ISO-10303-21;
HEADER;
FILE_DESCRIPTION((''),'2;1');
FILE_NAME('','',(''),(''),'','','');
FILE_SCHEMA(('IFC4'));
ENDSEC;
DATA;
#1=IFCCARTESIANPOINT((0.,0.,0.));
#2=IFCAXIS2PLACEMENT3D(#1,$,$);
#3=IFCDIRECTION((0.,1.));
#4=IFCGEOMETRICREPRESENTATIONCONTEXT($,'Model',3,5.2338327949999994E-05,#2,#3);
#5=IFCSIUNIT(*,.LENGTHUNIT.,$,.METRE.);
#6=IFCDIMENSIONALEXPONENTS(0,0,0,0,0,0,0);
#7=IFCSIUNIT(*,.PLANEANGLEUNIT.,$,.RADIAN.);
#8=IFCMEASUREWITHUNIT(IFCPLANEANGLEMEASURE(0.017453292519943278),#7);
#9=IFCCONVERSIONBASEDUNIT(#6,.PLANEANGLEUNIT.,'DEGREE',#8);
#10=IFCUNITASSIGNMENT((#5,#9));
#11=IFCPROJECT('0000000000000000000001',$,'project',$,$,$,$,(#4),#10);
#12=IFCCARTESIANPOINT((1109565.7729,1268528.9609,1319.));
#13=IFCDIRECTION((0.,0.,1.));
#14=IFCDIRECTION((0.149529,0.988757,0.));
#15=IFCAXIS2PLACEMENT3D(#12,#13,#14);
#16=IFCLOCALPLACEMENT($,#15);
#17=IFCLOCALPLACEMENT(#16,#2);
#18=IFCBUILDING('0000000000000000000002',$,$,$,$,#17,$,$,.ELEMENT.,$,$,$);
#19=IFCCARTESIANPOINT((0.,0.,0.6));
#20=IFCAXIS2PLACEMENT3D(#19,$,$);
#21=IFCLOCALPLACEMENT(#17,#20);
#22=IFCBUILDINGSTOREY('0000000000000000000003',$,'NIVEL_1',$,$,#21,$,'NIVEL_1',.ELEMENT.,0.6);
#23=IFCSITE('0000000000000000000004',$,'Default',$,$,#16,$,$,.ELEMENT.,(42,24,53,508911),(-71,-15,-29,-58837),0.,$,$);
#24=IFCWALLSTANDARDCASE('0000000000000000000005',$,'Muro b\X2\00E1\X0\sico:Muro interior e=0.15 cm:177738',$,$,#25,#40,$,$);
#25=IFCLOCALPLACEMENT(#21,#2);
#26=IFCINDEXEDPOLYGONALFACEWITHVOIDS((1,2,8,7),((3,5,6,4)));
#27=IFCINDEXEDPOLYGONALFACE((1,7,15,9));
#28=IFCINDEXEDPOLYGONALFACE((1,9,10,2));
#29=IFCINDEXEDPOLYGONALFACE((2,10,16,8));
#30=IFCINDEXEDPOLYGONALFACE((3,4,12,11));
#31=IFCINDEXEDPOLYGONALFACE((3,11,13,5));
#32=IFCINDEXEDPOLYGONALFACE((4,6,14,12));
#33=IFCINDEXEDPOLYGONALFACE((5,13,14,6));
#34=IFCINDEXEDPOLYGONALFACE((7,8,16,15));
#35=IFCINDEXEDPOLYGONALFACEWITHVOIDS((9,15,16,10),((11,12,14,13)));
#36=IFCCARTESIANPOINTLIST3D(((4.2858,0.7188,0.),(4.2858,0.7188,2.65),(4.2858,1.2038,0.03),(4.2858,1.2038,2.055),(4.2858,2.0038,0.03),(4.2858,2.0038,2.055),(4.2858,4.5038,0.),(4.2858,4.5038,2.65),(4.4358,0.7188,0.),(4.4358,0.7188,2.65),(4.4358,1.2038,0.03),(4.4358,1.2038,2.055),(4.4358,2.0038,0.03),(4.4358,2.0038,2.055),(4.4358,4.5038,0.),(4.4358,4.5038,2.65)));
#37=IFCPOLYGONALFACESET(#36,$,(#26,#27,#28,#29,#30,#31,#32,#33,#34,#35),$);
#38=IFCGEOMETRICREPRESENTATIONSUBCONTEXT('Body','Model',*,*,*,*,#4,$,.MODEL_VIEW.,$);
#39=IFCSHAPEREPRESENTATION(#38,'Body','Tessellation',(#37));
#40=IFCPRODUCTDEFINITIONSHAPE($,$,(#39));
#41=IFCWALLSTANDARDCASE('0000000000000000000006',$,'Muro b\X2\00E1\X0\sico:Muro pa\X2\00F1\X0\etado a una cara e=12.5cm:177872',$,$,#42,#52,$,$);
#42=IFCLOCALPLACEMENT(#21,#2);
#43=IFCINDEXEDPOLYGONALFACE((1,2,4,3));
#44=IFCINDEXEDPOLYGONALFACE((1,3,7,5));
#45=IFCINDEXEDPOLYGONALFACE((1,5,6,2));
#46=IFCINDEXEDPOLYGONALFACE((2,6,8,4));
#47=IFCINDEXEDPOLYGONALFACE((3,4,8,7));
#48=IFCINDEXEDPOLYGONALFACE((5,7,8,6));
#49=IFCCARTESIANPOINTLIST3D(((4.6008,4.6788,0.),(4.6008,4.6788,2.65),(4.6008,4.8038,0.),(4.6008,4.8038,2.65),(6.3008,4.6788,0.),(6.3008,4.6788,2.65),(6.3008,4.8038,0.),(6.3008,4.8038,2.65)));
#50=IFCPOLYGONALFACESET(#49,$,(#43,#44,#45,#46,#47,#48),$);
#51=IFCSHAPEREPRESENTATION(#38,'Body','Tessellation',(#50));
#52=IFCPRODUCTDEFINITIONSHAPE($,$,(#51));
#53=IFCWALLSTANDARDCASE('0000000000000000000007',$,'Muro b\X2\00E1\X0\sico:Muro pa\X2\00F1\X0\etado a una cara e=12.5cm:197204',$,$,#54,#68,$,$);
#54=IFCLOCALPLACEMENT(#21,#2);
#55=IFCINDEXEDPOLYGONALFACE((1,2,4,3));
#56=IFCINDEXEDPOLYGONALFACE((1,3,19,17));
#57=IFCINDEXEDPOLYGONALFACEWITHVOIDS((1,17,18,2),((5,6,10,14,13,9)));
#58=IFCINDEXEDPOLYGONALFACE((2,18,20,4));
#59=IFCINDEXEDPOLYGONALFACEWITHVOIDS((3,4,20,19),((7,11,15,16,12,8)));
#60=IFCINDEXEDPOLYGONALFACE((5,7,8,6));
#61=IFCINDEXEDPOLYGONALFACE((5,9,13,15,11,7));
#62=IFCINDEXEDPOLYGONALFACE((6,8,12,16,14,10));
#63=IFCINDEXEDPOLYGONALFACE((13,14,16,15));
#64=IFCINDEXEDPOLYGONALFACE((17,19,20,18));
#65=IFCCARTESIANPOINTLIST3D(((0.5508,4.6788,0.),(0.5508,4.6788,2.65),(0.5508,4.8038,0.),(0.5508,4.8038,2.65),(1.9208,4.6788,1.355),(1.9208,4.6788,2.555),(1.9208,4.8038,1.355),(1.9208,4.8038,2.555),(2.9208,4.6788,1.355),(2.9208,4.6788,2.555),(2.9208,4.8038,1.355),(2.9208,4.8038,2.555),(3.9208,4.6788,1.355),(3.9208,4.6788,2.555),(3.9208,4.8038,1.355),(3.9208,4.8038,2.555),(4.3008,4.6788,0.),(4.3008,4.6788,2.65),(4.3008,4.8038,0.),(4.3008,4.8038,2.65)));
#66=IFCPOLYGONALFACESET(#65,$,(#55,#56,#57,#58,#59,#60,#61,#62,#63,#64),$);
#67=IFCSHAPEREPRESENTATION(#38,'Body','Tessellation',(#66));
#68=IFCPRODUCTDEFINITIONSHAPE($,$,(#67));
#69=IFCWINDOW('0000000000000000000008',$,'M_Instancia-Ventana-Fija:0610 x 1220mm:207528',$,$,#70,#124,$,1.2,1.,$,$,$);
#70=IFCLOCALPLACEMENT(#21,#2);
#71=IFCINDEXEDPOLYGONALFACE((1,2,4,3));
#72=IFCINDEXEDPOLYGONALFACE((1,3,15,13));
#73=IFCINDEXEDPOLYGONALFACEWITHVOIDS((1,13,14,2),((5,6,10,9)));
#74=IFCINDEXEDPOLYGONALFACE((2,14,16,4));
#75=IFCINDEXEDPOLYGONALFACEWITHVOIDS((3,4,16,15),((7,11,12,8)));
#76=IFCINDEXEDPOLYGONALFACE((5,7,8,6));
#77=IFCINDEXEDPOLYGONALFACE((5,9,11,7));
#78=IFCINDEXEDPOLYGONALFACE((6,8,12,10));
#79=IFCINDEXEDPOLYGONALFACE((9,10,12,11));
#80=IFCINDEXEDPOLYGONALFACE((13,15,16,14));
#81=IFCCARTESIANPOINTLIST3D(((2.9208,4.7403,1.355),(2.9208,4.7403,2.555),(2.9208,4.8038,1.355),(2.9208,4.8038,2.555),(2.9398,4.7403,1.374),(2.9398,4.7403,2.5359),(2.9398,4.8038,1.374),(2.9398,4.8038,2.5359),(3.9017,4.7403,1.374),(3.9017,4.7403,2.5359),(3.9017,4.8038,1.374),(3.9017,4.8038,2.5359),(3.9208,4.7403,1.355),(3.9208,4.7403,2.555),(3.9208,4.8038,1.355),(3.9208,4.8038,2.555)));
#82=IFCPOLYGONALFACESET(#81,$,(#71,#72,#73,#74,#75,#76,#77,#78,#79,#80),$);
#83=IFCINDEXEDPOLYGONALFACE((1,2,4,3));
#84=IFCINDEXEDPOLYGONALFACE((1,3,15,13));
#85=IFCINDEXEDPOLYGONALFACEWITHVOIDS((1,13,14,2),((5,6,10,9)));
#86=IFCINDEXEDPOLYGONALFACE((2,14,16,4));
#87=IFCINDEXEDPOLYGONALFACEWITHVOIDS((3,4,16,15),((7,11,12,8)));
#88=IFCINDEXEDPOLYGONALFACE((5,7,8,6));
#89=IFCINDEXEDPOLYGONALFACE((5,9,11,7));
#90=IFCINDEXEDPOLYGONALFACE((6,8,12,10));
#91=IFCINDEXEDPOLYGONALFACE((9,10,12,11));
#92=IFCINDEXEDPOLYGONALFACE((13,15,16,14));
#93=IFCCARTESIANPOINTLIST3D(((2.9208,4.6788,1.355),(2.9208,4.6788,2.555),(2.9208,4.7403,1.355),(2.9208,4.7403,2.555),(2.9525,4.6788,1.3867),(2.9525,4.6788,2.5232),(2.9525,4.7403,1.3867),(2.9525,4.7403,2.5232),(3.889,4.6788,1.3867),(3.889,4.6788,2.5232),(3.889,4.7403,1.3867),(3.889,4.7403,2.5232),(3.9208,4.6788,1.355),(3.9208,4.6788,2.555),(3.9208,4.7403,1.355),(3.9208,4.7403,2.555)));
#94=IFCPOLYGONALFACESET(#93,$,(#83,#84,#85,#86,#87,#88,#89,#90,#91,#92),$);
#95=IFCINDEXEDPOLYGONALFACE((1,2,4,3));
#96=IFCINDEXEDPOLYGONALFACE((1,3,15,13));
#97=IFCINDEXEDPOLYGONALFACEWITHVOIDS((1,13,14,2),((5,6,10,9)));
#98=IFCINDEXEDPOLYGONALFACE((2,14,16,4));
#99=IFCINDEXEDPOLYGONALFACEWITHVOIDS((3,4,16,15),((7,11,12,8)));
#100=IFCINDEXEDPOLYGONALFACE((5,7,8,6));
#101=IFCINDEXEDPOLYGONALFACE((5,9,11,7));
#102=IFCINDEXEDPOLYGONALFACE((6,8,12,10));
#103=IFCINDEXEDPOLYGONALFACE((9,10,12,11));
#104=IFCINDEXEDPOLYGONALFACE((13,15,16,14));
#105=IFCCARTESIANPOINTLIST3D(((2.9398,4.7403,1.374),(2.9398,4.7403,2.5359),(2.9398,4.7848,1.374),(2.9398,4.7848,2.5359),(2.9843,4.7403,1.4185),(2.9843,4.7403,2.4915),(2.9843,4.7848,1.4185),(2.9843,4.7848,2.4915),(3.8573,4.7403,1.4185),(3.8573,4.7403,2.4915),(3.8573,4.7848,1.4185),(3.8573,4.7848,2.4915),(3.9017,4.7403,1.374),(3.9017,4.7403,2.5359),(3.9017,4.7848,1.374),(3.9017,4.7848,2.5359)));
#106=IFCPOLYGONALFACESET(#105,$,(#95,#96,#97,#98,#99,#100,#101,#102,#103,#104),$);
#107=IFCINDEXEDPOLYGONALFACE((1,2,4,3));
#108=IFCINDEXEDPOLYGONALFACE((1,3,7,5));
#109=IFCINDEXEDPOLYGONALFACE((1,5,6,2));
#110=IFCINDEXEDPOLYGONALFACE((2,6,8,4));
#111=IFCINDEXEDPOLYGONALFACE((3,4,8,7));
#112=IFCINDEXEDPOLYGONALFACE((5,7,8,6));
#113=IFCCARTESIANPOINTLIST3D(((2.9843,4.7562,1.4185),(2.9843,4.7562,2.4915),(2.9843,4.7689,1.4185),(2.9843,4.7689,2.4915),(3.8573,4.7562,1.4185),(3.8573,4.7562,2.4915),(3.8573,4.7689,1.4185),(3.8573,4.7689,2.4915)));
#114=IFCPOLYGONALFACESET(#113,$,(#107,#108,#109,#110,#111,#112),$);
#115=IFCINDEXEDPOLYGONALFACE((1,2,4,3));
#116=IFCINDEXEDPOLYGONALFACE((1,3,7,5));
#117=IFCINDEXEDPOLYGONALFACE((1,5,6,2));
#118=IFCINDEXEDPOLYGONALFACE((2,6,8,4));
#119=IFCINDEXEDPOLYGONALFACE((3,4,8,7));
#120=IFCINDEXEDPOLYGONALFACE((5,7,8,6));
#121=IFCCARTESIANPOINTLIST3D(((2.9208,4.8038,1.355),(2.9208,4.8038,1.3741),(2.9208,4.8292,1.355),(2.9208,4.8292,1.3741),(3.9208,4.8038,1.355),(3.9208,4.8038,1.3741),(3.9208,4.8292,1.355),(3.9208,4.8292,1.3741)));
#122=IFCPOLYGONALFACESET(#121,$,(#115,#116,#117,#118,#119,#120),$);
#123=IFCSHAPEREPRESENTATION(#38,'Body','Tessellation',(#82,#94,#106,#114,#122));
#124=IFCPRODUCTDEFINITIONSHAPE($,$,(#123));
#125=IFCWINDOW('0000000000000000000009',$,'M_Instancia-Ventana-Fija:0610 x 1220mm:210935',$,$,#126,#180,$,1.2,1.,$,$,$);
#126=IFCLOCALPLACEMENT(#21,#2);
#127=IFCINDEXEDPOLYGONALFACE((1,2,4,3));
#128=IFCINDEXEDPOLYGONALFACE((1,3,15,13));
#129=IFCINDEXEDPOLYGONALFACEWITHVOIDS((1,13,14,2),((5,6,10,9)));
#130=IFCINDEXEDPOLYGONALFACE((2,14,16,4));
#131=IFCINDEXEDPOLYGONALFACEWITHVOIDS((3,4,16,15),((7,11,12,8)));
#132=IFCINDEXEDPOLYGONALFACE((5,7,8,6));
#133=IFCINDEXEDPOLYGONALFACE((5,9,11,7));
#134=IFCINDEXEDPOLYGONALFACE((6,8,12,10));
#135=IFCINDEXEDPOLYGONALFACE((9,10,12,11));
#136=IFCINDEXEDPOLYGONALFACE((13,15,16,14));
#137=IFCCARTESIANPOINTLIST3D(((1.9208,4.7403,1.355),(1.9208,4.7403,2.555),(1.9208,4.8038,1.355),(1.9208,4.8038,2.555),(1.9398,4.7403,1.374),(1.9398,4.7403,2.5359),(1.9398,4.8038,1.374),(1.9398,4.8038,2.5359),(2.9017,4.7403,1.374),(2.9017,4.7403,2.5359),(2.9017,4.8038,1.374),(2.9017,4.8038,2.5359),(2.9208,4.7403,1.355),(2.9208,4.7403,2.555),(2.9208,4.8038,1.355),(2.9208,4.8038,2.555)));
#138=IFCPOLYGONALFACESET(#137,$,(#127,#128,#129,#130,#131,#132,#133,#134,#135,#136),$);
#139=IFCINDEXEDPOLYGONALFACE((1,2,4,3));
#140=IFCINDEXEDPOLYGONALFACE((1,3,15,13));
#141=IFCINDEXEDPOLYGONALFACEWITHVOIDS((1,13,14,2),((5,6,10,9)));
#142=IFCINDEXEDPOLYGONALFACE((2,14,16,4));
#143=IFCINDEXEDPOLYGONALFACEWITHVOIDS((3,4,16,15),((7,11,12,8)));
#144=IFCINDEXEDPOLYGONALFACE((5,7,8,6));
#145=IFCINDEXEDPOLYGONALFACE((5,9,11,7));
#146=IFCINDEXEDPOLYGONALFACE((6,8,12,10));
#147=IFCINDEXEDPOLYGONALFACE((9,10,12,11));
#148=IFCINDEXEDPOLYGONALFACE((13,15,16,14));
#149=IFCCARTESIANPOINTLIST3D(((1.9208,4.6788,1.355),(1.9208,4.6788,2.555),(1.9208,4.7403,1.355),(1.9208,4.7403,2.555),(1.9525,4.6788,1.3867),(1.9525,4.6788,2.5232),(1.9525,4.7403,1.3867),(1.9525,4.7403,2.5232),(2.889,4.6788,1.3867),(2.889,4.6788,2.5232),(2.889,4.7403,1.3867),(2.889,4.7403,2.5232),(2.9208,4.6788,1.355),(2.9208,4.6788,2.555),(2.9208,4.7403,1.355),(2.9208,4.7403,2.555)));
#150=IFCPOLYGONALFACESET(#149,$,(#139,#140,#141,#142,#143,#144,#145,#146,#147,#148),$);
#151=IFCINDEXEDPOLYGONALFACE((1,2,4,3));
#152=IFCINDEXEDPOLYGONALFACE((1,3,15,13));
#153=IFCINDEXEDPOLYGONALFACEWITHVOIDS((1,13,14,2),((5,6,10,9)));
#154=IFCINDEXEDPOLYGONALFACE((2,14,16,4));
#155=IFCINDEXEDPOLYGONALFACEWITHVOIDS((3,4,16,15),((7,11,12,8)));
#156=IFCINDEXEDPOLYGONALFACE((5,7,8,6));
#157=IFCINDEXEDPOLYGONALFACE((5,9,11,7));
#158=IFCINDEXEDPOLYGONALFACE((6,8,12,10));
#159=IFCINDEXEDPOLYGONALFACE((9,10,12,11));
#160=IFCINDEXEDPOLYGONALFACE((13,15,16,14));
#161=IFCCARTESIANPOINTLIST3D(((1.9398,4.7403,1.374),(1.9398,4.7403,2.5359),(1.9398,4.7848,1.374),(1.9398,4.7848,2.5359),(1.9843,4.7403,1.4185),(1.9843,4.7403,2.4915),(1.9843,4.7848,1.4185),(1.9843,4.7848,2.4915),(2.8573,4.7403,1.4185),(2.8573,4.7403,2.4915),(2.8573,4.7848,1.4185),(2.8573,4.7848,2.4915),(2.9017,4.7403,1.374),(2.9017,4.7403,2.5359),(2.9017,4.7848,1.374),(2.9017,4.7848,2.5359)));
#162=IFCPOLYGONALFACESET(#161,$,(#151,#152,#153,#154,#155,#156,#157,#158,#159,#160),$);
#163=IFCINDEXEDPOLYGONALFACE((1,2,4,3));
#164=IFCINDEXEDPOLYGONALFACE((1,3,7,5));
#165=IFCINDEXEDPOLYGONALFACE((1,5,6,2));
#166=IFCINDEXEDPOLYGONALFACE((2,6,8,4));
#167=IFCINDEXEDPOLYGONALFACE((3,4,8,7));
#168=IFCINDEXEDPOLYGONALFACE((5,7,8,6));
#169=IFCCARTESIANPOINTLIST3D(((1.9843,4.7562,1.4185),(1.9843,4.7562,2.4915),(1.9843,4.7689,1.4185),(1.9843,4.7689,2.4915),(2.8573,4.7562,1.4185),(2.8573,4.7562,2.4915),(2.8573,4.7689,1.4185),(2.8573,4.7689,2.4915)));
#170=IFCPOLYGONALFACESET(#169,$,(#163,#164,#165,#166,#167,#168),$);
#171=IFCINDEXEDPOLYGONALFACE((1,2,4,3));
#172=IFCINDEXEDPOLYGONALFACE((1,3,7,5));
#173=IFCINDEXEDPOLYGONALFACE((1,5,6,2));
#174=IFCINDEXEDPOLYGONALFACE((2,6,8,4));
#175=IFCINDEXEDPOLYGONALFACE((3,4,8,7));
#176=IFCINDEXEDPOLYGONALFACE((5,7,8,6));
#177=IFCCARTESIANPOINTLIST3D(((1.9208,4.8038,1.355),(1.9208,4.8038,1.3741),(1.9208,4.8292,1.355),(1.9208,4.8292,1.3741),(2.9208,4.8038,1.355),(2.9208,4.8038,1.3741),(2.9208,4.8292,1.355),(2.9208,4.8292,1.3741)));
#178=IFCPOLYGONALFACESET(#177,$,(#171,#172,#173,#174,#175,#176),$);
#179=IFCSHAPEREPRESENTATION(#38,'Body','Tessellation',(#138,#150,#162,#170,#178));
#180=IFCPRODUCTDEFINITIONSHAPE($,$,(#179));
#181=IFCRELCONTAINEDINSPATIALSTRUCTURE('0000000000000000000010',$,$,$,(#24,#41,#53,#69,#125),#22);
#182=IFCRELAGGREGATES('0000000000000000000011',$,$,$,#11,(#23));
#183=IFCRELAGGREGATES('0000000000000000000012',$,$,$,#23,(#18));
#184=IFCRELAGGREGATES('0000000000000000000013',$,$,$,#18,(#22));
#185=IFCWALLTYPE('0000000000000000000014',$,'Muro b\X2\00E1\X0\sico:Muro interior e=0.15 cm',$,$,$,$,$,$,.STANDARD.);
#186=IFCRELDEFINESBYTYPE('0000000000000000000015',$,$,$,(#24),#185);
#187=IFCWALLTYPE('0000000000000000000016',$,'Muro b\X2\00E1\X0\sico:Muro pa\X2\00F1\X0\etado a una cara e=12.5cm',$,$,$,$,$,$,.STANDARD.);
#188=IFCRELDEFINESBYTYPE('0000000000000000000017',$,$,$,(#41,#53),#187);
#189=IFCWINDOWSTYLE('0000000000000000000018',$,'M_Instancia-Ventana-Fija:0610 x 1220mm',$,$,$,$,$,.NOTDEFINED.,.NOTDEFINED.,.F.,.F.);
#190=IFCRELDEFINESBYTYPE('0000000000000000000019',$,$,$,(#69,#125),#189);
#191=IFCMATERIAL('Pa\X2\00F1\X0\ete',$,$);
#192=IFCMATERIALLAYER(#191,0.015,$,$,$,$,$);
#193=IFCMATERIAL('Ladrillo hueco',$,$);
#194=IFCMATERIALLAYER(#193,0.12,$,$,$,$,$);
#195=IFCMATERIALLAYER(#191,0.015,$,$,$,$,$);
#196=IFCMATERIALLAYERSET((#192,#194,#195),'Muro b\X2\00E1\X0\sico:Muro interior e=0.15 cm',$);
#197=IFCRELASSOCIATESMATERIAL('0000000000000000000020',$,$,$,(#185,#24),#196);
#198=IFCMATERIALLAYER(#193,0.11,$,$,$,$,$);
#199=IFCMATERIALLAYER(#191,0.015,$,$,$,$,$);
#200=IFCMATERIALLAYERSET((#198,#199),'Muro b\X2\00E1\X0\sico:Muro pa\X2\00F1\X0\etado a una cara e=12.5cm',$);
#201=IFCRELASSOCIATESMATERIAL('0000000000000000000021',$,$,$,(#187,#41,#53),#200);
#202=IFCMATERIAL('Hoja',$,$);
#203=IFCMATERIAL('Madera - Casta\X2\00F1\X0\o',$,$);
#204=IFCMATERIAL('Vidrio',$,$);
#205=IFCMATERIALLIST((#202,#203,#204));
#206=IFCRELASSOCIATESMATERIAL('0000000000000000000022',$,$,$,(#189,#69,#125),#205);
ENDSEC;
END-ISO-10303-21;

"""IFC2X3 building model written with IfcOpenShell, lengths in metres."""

from ifc_helpers import new_model, entity, si_unit, converted_unit, direction, frame, frame_2d, origin, origin_2d_with_axis, place, context, subcontext, project, spatial, polyline, rectangle, outline, extrude, source, transform, mapped, material, material_list, layer, layer_set, layer_usage, type_object, type_shapes, element, fill, save


model = new_model("IFC2X3")

# Units and contexts
model_context = context("Model", 3, precision=5.2338327949999994e-05, world=origin(), true_north=direction((0.0, 1.0)))
body_context = subcontext(model_context, "Body", "Model", "MODEL_VIEW")
ifc_project = project(units=[si_unit("LENGTHUNIT", "METRE"), converted_unit("PLANEANGLEUNIT", "DEGREE", entity("IfcPlaneAngleMeasure", 0.017453292519943278), si_unit("PLANEANGLEUNIT", "RADIAN"), dimensions=[0, 0, 0, 0, 0, 0, 0])], contexts=[model_context])

# Site, building, storey
site_placement = place(None, frame((1109565.7729, 1268528.9609, 1319.0), z_axis=(0.0, 0.0, 1.0), x_axis=(0.149529, 0.988757, 0.0)))
site = spatial("IfcSite", under=ifc_project, at=site_placement, Name="Default", CompositionType="ELEMENT", RefLatitude=(42, 24, 53, 508911), RefLongitude=(-71, -15, -29, -58837), RefElevation=0.0)
building_placement = place(site_placement, origin())
building = spatial("IfcBuilding", under=site, at=building_placement, CompositionType="ELEMENT")
storey_placement = place(building_placement, frame((0.0, 0.0, 0.6)))
storey = spatial("IfcBuildingStorey", under=building, at=storey_placement, Name="NIVEL_1", LongName="NIVEL_1", CompositionType="ELEMENT", Elevation=0.6)

# Wall, opening
ifc_material_1 = material(Name="Pañete")
ifc_layer_1 = layer(ifc_material_1, 0.015)
ifc_material_2 = material(Name="Ladrillo hueco")
ifc_layer_2 = layer(ifc_material_2, 0.12)
ifc_layer_3 = layer(ifc_material_1, 0.015)
ifc_layer_set_1 = layer_set([ifc_layer_1, ifc_layer_2, ifc_layer_3], Name="Muro básico:Muro interior e=0.15 cm")
ifc_layer_usage_1 = layer_usage(ifc_layer_set_1, "AXIS2", "POSITIVE", -0.075)
wall_type_1 = type_object("IfcWallType", Name="Muro básico:Muro interior e=0.15 cm", PredefinedType="STANDARD", material=ifc_layer_set_1)
wall_1_placement = place(storey_placement, frame((4.3608, 4.5038, 0.0), z_axis=(0.0, 0.0, 1.0), x_axis=(0.0, -1.0, 0.0)))
wall_1 = element("IfcWallStandardCase", 1, at=wall_1_placement, inside=storey, type_object=wall_type_1, material=ifc_layer_usage_1, Name="Muro básico:Muro interior e=0.15 cm:177738", context=body_context, shape_type="SweptSolid", body=[
    extrude(rectangle(XDim=3.785, YDim=0.15, at=frame_2d((1.8925, 0.0), x_axis=(-1.0, 0.0))), origin(), (0.0, 0.0, 1.0), 2.65),
])
opening_1_placement = place(wall_1_placement, frame((2.5, -0.075, 0.03)))
element("IfcOpeningElement", 2, at=opening_1_placement, cuts=wall_1, ObjectType="Opening", context=body_context, shape_type="SweptSolid", body=[
    extrude(rectangle(XDim=2.025, YDim=0.8, at=frame_2d((1.0125, 0.4), x_axis=(1.0, 0.0))), frame((0.0, 0.0, 0.0), z_axis=(0.0, 1.0, 0.0), x_axis=(0.0, 0.0, 1.0)), (0.0, 0.0, 1.0), 0.15),
])

# Wall
ifc_layer_4 = layer(ifc_material_2, 0.11)
ifc_layer_5 = layer(ifc_material_1, 0.015)
ifc_layer_set_2 = layer_set([ifc_layer_4, ifc_layer_5], Name="Muro básico:Muro pañetado a una cara e=12.5cm")
ifc_layer_usage_2 = layer_usage(ifc_layer_set_2, "AXIS2", "NEGATIVE", 0.0625)
wall_type_2 = type_object("IfcWallType", Name="Muro básico:Muro pañetado a una cara e=12.5cm", PredefinedType="STANDARD", material=ifc_layer_set_2)
wall_2_placement = place(storey_placement, frame((4.6008, 4.7413, 0.0)))
element("IfcWallStandardCase", 3, at=wall_2_placement, inside=storey, type_object=wall_type_2, material=ifc_layer_usage_2, Name="Muro básico:Muro pañetado a una cara e=12.5cm:177872", context=body_context, shape_type="SweptSolid", body=[
    extrude(rectangle(XDim=1.7, YDim=0.125, at=frame_2d((0.85, 0.0), x_axis=(-1.0, 0.0))), origin(), (0.0, 0.0, 1.0), 2.65),
])

# Wall, openings, windows
ifc_material_3 = material(Name="Hoja")
ifc_material_4 = material(Name="Madera - Castaño")
ifc_material_5 = material(Name="Vidrio")
ifc_material_list = material_list([ifc_material_3, ifc_material_4, ifc_material_5])
ifc_layer_usage_3 = layer_usage(ifc_layer_set_2, "AXIS2", "POSITIVE", -0.0625)
wall_3_placement = place(storey_placement, frame((4.3008, 4.7413, 0.0), z_axis=(0.0, 0.0, 1.0), x_axis=(-1.0, 0.0, 0.0)))
wall_3 = element("IfcWallStandardCase", 4, at=wall_3_placement, inside=storey, type_object=wall_type_2, material=ifc_layer_usage_3, Name="Muro básico:Muro pañetado a una cara e=12.5cm:197204", context=body_context, shape_type="SweptSolid", body=[
    extrude(rectangle(XDim=3.75, YDim=0.125, at=frame_2d((1.875, 0.0), x_axis=(-1.0, 0.0))), origin(), (0.0, 0.0, 1.0), 2.65),
])
opening_2_placement = place(wall_3_placement, frame((1.38, 0.0625, 1.355)))
opening_2 = element("IfcOpeningElement", 5, at=opening_2_placement, cuts=wall_3, ObjectType="Opening", context=body_context, shape_type="SweptSolid", body=[
    extrude(rectangle(XDim=1.2, YDim=1.0, at=frame_2d((0.6, 0.5), x_axis=(-1.0, 0.0))), frame((0.0, 0.0, 0.0), z_axis=(0.0, -1.0, 0.0), x_axis=(0.0, 0.0, 1.0)), (0.0, 0.0, 1.0), 0.125),
])
opening_3_placement = place(wall_3_placement, frame((2.38, 0.0625, 1.355)))
opening_3 = element("IfcOpeningElement", 6, at=opening_3_placement, cuts=wall_3, ObjectType="Opening", context=body_context, shape_type="SweptSolid", body=[
    extrude(rectangle(XDim=1.2, YDim=1.0, at=frame_2d((0.6, 0.5), x_axis=(-1.0, 0.0))), frame((0.0, 0.0, 0.0), z_axis=(0.0, -1.0, 0.0), x_axis=(0.0, 0.0, 1.0)), (0.0, 0.0, 1.0), 0.125),
])
window_style_1 = type_object("IfcWindowStyle", Name="M_Instancia-Ventana-Fija:0610 x 1220mm", ConstructionType="NOTDEFINED", OperationType="NOTDEFINED", ParameterTakesPrecedence=False, Sizeable=False, material=ifc_material_list)
shared_shape_1 = source(origin(), body_context, "Body", "SweptSolid", [
    extrude(outline(polyline([(-0.6, -0.5), (0.6, -0.5), (0.6, 0.5), (-0.6, 0.5), (-0.6, -0.5)]), holes=[polyline([(-0.5809, -0.4809), (-0.5809, 0.481), (0.581, 0.481), (0.581, -0.4809), (-0.5809, -0.4809)])]), frame((0.5, 0.0616, 0.6), z_axis=(0.0, 1.0, 0.0), x_axis=(0.0, 0.0, -1.0)), (0.0, 0.0, 1.0), 0.0635),
    extrude(outline(polyline([(-0.5, -0.6), (0.5, -0.6), (0.5, 0.6), (-0.5, 0.6), (-0.5, -0.6)]), holes=[polyline([(-0.4683, -0.5682), (-0.4683, 0.5683), (0.4682, 0.5683), (0.4682, -0.5682), (-0.4683, -0.5682)])]), frame((0.5, 0.0, 0.6), z_axis=(0.0, 1.0, 0.0), x_axis=(1.0, 0.0, 0.0)), (0.0, 0.0, 1.0), 0.0616),
    extrude(outline(polyline([(-0.4809, -0.581), (0.4809, -0.581), (0.4809, 0.581), (-0.4809, 0.581), (-0.4809, -0.581)]), holes=[polyline([(-0.4365, -0.5365), (-0.4365, 0.5365), (0.4365, 0.5365), (0.4365, -0.5365), (-0.4365, -0.5365)])]), frame((0.5, 0.0616, 0.6), z_axis=(0.0, 1.0, 0.0), x_axis=(1.0, 0.0, 0.0)), (0.0, 0.0, 1.0), 0.0444),
    extrude(rectangle(XDim=0.0127, YDim=0.873, at=origin_2d_with_axis()), frame((0.5, 0.0838, 0.0635), z_axis=(0.0, 0.0, 1.0), x_axis=(0.0, 1.0, 0.0)), (0.0, 0.0, 1.0), 1.073),
    extrude(rectangle(XDim=0.0254, YDim=1.0, at=origin_2d_with_axis()), frame((0.5, 0.1377, 0.0), z_axis=(0.0, 0.0, 1.0), x_axis=(0.0, -1.0, 0.0)), (0.0, 0.0, 1.0), 0.019),
])
type_shapes(window_style_1, [shared_shape_1])
window_1_placement = place(opening_2_placement, frame((0.0, 0.0, 0.0), z_axis=(0.0, 0.0, 1.0), x_axis=(-1.0, 0.0, 0.0)))
window_1 = element("IfcWindow", 7, at=window_1_placement, inside=storey, type_object=window_style_1, material=ifc_material_list, Name="M_Instancia-Ventana-Fija:0610 x 1220mm:207528", OverallHeight=1.2, OverallWidth=1.0, context=body_context, shape_type="MappedRepresentation", body=[
    mapped(shared_shape_1, transform((0.0, 0.0, 0.0), scale=1.0)),
])
fill(opening_2, window_1)
window_2_placement = place(opening_3_placement, frame((0.0, 0.0, 0.0), z_axis=(0.0, 0.0, 1.0), x_axis=(-1.0, 0.0, 0.0)))
window_2 = element("IfcWindow", 8, at=window_2_placement, inside=storey, type_object=window_style_1, material=ifc_material_list, Name="M_Instancia-Ventana-Fija:0610 x 1220mm:210935", OverallHeight=1.2, OverallWidth=1.0, context=body_context, shape_type="MappedRepresentation", body=[
    mapped(shared_shape_1, transform((0.0, 0.0, 0.0), scale=1.0)),
])
fill(opening_3, window_2)

save(model, "model.ifc")
